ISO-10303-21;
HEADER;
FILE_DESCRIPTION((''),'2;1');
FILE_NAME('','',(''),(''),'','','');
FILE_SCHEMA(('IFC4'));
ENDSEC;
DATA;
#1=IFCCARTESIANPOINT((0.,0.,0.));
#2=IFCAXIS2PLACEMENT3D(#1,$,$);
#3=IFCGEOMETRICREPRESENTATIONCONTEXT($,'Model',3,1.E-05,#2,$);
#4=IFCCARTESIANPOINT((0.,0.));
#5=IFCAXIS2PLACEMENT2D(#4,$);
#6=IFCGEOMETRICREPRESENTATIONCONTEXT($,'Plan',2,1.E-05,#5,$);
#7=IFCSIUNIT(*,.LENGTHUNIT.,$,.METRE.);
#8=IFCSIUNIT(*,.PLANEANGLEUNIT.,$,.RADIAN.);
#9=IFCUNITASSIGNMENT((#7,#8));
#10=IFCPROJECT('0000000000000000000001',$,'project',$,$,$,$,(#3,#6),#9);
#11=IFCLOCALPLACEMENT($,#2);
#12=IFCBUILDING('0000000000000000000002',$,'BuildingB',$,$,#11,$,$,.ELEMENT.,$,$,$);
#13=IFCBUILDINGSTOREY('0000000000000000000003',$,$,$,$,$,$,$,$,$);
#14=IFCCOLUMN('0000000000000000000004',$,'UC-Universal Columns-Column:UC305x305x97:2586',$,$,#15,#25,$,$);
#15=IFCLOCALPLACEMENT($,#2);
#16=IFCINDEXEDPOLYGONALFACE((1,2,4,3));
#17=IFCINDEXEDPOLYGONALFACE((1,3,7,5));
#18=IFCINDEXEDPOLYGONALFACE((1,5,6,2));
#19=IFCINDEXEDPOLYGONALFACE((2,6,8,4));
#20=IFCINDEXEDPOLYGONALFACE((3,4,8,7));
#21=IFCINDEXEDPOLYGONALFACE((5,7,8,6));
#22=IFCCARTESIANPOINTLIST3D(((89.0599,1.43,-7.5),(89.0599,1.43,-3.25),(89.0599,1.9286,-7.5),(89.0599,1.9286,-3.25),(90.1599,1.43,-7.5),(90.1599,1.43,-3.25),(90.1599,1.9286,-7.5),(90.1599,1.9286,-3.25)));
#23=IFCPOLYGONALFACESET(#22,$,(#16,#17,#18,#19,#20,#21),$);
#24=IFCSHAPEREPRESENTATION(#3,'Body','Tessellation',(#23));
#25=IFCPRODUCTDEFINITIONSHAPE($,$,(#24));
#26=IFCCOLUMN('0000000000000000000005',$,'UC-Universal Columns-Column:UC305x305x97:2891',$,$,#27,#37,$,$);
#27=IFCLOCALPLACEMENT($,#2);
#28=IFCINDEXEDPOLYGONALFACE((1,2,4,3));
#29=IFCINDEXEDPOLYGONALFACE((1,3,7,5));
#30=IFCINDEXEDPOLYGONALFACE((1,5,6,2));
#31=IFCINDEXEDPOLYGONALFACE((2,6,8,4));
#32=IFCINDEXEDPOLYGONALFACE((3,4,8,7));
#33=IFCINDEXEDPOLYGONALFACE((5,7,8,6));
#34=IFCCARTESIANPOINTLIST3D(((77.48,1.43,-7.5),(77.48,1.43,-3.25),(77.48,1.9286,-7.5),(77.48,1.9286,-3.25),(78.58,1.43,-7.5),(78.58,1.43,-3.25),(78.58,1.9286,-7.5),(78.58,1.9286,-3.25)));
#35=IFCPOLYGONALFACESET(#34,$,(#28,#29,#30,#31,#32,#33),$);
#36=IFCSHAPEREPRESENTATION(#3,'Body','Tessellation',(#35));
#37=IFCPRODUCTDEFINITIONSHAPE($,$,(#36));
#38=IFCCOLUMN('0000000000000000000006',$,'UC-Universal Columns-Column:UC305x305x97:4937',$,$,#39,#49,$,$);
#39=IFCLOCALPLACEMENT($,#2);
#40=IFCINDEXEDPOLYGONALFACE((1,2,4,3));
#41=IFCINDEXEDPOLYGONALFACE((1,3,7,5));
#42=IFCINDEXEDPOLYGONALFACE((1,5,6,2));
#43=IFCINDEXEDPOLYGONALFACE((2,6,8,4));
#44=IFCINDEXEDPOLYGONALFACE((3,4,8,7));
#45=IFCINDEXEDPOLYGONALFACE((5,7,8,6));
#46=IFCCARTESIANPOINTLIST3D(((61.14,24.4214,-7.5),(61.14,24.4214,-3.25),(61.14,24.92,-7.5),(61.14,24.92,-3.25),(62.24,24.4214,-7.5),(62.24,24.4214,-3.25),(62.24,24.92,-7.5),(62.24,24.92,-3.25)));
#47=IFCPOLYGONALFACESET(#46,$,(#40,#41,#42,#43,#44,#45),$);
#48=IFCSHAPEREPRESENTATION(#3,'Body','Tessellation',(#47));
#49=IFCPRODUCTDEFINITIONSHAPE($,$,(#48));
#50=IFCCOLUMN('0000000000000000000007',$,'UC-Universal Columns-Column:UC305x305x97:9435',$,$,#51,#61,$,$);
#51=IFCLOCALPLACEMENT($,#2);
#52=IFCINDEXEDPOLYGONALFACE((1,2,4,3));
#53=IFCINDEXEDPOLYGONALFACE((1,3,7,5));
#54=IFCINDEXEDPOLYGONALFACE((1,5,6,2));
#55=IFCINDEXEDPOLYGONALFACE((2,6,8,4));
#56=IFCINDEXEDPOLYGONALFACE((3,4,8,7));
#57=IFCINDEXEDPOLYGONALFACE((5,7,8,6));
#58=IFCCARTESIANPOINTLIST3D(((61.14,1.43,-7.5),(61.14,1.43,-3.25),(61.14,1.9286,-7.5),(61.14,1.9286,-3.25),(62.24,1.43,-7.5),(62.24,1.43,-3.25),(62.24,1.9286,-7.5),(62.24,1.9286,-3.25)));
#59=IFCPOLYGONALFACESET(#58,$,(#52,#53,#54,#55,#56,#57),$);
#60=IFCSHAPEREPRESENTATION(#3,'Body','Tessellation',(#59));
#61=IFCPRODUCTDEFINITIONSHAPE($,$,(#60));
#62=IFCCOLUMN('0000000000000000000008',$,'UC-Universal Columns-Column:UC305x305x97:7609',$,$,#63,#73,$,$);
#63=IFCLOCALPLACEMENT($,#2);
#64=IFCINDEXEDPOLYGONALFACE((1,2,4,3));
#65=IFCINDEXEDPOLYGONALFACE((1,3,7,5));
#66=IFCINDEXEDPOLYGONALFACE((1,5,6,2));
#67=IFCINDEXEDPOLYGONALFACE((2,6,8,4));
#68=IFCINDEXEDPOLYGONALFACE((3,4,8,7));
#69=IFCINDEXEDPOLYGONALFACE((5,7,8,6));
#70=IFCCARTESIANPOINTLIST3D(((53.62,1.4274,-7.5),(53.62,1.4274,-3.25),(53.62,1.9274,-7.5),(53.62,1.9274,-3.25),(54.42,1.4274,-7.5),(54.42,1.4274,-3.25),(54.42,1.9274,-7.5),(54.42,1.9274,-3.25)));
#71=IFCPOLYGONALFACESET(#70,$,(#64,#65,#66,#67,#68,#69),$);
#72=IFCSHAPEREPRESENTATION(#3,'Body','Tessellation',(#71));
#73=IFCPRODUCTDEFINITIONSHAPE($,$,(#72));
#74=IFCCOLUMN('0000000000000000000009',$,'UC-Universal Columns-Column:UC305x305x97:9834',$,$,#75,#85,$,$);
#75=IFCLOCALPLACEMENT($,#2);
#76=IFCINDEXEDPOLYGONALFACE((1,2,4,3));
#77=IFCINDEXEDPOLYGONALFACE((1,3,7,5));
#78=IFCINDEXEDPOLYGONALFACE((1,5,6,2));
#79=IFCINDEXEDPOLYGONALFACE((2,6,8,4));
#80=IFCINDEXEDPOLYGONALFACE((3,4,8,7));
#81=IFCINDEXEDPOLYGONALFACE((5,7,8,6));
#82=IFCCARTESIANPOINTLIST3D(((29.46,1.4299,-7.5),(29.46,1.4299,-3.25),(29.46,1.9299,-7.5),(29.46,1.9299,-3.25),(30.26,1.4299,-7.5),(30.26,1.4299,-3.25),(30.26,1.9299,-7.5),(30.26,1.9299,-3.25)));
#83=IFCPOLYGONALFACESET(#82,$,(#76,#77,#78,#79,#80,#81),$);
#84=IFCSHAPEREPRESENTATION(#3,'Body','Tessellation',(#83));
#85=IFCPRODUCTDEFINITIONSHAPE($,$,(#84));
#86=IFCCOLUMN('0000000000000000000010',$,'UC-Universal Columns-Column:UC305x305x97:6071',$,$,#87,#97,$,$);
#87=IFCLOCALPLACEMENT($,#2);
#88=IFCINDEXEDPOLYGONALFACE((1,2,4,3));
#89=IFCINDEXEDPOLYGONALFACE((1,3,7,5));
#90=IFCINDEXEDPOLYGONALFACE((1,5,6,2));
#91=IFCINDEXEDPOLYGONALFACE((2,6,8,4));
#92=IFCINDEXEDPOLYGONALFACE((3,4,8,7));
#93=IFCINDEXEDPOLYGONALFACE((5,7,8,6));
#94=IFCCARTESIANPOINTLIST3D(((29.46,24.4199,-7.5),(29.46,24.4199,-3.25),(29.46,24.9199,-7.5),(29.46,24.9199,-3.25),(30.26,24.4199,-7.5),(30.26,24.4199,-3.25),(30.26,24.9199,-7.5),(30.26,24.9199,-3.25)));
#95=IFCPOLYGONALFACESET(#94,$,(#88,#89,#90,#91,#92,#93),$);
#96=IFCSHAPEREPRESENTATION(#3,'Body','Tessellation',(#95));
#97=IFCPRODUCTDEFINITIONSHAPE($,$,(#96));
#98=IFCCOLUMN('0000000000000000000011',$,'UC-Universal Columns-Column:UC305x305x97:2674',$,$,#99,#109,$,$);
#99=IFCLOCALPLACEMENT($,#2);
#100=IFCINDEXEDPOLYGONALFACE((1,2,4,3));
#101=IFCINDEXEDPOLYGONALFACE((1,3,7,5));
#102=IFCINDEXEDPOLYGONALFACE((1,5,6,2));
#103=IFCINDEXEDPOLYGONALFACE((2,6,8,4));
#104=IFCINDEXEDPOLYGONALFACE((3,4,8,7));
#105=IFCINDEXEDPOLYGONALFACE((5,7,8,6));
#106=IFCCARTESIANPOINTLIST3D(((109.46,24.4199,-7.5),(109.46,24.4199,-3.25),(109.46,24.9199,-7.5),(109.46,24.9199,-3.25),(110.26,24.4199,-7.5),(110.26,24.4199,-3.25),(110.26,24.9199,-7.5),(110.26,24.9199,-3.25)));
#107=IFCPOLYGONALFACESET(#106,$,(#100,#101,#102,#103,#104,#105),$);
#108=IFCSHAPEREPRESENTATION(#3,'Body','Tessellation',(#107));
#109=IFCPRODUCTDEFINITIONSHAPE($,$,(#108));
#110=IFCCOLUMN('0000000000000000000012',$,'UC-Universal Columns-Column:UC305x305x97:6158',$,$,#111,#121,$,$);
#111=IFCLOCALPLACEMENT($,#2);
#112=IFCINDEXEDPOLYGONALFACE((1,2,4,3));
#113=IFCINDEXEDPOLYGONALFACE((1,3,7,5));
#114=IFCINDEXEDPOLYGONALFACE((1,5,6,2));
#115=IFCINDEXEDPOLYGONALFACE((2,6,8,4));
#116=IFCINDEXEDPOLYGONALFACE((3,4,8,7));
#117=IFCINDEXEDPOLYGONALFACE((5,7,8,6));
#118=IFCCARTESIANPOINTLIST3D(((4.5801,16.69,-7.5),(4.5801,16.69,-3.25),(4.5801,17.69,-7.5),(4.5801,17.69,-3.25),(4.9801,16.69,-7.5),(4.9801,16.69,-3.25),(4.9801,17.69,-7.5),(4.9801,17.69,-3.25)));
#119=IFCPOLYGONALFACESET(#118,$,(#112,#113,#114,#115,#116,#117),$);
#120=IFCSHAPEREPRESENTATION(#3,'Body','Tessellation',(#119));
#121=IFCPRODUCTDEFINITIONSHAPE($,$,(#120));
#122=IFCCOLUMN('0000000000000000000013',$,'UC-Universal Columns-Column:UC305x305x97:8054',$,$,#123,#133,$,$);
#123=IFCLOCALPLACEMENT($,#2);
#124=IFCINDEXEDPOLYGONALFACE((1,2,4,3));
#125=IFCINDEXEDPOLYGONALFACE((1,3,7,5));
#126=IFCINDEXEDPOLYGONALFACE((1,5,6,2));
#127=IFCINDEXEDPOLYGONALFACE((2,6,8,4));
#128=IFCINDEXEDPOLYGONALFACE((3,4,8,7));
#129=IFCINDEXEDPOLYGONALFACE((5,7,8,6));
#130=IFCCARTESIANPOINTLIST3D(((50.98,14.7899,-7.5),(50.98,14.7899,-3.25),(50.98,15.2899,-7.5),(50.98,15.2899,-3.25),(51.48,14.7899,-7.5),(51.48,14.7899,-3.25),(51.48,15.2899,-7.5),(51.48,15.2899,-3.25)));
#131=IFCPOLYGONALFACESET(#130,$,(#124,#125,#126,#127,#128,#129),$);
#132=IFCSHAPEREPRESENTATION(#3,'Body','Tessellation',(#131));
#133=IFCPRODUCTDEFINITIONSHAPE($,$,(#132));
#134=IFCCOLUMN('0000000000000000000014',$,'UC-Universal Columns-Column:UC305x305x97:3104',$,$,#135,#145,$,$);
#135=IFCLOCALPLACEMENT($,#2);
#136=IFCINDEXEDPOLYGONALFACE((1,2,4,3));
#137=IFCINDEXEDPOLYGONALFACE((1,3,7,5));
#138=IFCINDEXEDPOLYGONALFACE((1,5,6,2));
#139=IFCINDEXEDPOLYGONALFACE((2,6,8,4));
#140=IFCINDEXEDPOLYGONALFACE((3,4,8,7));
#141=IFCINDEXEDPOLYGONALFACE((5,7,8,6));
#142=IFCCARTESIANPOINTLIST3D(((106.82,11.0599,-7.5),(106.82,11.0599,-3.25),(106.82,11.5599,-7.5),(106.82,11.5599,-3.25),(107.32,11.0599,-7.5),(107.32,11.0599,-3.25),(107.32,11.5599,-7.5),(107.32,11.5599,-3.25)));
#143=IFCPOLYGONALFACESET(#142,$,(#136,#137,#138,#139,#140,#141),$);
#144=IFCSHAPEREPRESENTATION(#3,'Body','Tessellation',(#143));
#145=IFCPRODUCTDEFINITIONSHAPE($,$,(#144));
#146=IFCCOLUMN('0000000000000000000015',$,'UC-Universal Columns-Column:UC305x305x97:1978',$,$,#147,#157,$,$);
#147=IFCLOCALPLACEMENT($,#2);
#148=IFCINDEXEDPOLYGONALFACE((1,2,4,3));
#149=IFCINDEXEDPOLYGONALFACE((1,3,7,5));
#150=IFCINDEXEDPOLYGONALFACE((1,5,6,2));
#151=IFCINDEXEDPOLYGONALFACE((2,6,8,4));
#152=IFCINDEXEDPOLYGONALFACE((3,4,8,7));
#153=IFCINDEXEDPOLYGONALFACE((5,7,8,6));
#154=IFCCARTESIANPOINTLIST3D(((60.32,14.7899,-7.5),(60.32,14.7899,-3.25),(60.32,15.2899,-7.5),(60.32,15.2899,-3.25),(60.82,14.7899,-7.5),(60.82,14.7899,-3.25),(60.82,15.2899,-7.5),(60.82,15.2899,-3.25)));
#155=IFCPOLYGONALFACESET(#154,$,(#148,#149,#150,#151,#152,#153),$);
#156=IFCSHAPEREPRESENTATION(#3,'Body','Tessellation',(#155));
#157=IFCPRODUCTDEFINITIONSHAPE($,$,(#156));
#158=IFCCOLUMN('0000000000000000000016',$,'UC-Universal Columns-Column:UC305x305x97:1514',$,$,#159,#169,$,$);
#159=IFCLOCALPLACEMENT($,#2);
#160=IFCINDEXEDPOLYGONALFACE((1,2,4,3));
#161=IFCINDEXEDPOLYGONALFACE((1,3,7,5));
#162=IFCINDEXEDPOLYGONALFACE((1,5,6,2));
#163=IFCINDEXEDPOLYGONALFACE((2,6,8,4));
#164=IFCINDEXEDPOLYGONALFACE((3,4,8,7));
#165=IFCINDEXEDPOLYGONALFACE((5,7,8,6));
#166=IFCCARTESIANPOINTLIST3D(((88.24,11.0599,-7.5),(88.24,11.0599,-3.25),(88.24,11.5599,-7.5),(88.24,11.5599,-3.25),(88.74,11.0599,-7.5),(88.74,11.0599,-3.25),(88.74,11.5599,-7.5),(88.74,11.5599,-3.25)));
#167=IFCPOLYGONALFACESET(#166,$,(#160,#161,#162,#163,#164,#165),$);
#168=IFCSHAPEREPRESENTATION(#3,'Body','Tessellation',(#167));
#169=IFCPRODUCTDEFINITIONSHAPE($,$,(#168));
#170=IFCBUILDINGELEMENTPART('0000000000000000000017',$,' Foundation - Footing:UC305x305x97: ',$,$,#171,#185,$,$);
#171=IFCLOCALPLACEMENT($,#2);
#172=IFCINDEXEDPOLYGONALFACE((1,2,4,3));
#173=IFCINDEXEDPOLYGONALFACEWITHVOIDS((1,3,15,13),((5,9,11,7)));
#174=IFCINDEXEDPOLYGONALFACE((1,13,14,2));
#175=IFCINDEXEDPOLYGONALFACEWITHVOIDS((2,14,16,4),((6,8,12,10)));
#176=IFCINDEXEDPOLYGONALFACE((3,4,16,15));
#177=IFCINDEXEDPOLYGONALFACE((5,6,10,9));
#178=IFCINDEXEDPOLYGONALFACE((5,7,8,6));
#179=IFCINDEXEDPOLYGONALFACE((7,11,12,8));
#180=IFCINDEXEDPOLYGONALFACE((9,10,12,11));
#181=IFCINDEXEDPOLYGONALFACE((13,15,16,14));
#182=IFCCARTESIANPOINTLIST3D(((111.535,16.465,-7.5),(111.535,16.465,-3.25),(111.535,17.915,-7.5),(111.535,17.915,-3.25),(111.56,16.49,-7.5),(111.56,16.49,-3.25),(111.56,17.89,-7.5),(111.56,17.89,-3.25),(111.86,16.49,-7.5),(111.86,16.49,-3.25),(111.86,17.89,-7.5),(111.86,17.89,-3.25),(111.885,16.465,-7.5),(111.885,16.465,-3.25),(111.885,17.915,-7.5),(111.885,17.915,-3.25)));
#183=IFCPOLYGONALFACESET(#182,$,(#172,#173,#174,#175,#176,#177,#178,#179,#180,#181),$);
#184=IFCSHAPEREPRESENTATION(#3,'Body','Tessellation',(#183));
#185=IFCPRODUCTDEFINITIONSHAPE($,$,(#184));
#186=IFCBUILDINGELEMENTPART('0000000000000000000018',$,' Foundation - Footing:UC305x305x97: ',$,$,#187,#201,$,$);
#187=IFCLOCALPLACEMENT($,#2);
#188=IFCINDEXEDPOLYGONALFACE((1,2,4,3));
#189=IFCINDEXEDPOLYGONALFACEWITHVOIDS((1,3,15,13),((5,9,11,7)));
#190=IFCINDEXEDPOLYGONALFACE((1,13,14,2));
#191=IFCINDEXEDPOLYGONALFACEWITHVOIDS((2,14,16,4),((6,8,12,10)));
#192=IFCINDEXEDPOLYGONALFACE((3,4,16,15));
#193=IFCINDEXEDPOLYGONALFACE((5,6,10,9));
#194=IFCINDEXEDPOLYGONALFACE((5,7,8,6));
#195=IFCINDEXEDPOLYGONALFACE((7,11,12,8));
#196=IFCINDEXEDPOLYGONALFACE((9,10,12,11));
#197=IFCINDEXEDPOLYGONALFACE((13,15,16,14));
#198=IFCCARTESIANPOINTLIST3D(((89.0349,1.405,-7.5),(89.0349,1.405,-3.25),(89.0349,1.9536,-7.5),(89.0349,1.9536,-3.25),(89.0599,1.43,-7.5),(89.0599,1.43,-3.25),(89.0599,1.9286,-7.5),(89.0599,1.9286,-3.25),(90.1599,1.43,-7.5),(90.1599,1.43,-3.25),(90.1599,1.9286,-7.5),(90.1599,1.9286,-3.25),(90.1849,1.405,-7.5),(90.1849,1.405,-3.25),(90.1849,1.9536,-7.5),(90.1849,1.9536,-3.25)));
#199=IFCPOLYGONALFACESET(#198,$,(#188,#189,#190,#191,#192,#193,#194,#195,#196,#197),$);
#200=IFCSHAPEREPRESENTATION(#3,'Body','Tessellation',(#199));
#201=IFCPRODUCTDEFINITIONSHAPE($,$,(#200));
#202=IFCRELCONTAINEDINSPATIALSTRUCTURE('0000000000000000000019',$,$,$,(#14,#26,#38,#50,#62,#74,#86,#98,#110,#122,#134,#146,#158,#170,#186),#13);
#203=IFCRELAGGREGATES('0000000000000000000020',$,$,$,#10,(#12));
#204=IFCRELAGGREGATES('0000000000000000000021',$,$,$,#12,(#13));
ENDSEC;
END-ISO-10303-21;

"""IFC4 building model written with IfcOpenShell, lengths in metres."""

from ifc_helpers import new_model, si_unit, origin, origin_2d, place, context, project, spatial, polyline, outline, extrude, element, save


model = new_model("IFC4")

# Units and contexts
model_context = context("Model", 3, precision=1e-05, world=origin())
plan_context = context("Plan", 2, precision=1e-05, world=origin_2d())
ifc_project = project(units=[si_unit("LENGTHUNIT", "METRE"), si_unit("PLANEANGLEUNIT", "RADIAN")], contexts=[model_context, plan_context])

# Building, storey
building_placement = place(None, origin())
building = spatial("IfcBuilding", under=ifc_project, at=building_placement, Name="BuildingB", CompositionType="ELEMENT")
storey = spatial("IfcBuildingStorey", under=building)

# Columns
element("IfcColumn", 1, inside=storey, Name="UC-Universal Columns-Column:UC305x305x97:2586", context=model_context, shape_type="SweptSolid", body=[
    extrude(outline(polyline([(90.1599, 1.43, -7.5), (89.0599, 1.43, -7.5), (89.0599, 1.9286, -7.5), (90.1599, 1.9286, -7.5), (90.1599, 1.43, -7.5)])), None, (0.0, 0.0, 1.0), 4.25),
])
element("IfcColumn", 2, inside=storey, Name="UC-Universal Columns-Column:UC305x305x97:2891", context=model_context, shape_type="SweptSolid", body=[
    extrude(outline(polyline([(77.48, 1.43, -7.5), (78.58, 1.43, -7.5), (78.58, 1.9286, -7.5), (77.48, 1.9286, -7.5), (77.48, 1.43, -7.5)])), None, (0.0, 0.0, 1.0), 4.25),
])
element("IfcColumn", 3, inside=storey, Name="UC-Universal Columns-Column:UC305x305x97:4937", context=model_context, shape_type="SweptSolid", body=[
    extrude(outline(polyline([(61.14, 24.4214, -7.5), (62.24, 24.4214, -7.5), (62.24, 24.92, -7.5), (61.14, 24.92, -7.5), (61.14, 24.4214, -7.5)])), None, (0.0, 0.0, 1.0), 4.25),
])
element("IfcColumn", 4, inside=storey, Name="UC-Universal Columns-Column:UC305x305x97:9435", context=model_context, shape_type="SweptSolid", body=[
    extrude(outline(polyline([(61.14, 1.43, -7.5), (62.24, 1.43, -7.5), (62.24, 1.9286, -7.5), (61.14, 1.9286, -7.5), (61.14, 1.43, -7.5)])), None, (0.0, 0.0, 1.0), 4.25),
])
element("IfcColumn", 5, inside=storey, Name="UC-Universal Columns-Column:UC305x305x97:7609", context=model_context, shape_type="SweptSolid", body=[
    extrude(outline(polyline([(54.42, 1.4274, -7.5), (53.62, 1.4274, -7.5), (53.62, 1.9274, -7.5), (54.42, 1.9274, -7.5), (54.42, 1.4274, -7.5)])), None, (0.0, 0.0, 1.0), 4.25),
])
element("IfcColumn", 6, inside=storey, Name="UC-Universal Columns-Column:UC305x305x97:9834", context=model_context, shape_type="SweptSolid", body=[
    extrude(outline(polyline([(30.26, 1.4299, -7.5), (29.46, 1.4299, -7.5), (29.46, 1.9299, -7.5), (30.26, 1.9299, -7.5), (30.26, 1.4299, -7.5)])), None, (0.0, 0.0, 1.0), 4.25),
])
element("IfcColumn", 7, inside=storey, Name="UC-Universal Columns-Column:UC305x305x97:6071", context=model_context, shape_type="SweptSolid", body=[
    extrude(outline(polyline([(30.26, 24.4199, -7.5), (29.46, 24.4199, -7.5), (29.46, 24.9199, -7.5), (30.26, 24.9199, -7.5), (30.26, 24.4199, -7.5)])), None, (0.0, 0.0, 1.0), 4.25),
])
element("IfcColumn", 8, inside=storey, Name="UC-Universal Columns-Column:UC305x305x97:2674", context=model_context, shape_type="SweptSolid", body=[
    extrude(outline(polyline([(110.26, 24.4199, -7.5), (109.46, 24.4199, -7.5), (109.46, 24.9199, -7.5), (110.26, 24.9199, -7.5), (110.26, 24.4199, -7.5)])), None, (0.0, 0.0, 1.0), 4.25),
])
element("IfcColumn", 9, inside=storey, Name="UC-Universal Columns-Column:UC305x305x97:6158", context=model_context, shape_type="SweptSolid", body=[
    extrude(outline(polyline([(4.5801, 17.69, -7.5), (4.9801, 17.69, -7.5), (4.9801, 16.69, -7.5), (4.5801, 16.69, -7.5), (4.5801, 17.69, -7.5)])), None, (0.0, 0.0, 1.0), 4.25),
])
element("IfcColumn", 10, inside=storey, Name="UC-Universal Columns-Column:UC305x305x97:8054", context=model_context, shape_type="SweptSolid", body=[
    extrude(outline(polyline([(50.98, 15.2899, -7.5), (51.48, 15.2899, -7.5), (51.48, 14.7899, -7.5), (50.98, 14.7899, -7.5), (50.98, 15.2899, -7.5)])), None, (0.0, 0.0, 1.0), 4.25),
])
element("IfcColumn", 11, inside=storey, Name="UC-Universal Columns-Column:UC305x305x97:3104", context=model_context, shape_type="SweptSolid", body=[
    extrude(outline(polyline([(106.82, 11.0599, -7.5), (107.32, 11.0599, -7.5), (107.32, 11.5599, -7.5), (106.82, 11.5599, -7.5), (106.82, 11.0599, -7.5)])), None, (0.0, 0.0, 1.0), 4.25),
])
element("IfcColumn", 12, inside=storey, Name="UC-Universal Columns-Column:UC305x305x97:1978", context=model_context, shape_type="SweptSolid", body=[
    extrude(outline(polyline([(60.82, 15.2899, -7.5), (60.32, 15.2899, -7.5), (60.32, 14.7899, -7.5), (60.82, 14.7899, -7.5), (60.82, 15.2899, -7.5)])), None, (0.0, 0.0, 1.0), 4.25),
])
element("IfcColumn", 13, inside=storey, Name="UC-Universal Columns-Column:UC305x305x97:1514", context=model_context, shape_type="SweptSolid", body=[
    extrude(outline(polyline([(88.74, 11.0599, -7.5), (88.24, 11.0599, -7.5), (88.24, 11.5599, -7.5), (88.74, 11.5599, -7.5), (88.74, 11.0599, -7.5)])), None, (0.0, 0.0, 1.0), 4.25),
])

# Building element parts, openings
building_element_part_1 = element("IfcBuildingElementPart", 14, inside=storey, Name=" Foundation - Footing:UC305x305x97: ", context=model_context, shape_type="SweptSolid", body=[
    extrude(outline(polyline([(111.885, 17.915, -7.5), (111.535, 17.915, -7.5), (111.535, 16.465, -7.5), (111.885, 16.465, -7.5), (111.885, 17.915, -7.5)])), None, (0.0, 0.0, 1.0), 4.25),
])
element("IfcOpeningElement", 15, inside=storey, cuts=building_element_part_1, context=model_context, shape_type="SweptSolid", body=[
    extrude(outline(polyline([(111.86, 17.89, -7.5), (111.56, 17.89, -7.5), (111.56, 16.49, -7.5), (111.86, 16.49, -7.5), (111.86, 17.89, -7.5)])), None, (0.0, 0.0, 1.0), 4.25),
])
building_element_part_2 = element("IfcBuildingElementPart", 16, inside=storey, Name=" Foundation - Footing:UC305x305x97: ", context=model_context, shape_type="SweptSolid", body=[
    extrude(outline(polyline([(90.1849, 1.405, -7.5), (89.0349, 1.405, -7.5), (89.0349, 1.9536, -7.5), (90.1849, 1.9536, -7.5), (90.1849, 1.405, -7.5)])), None, (0.0, 0.0, 1.0), 4.25),
])
element("IfcOpeningElement", 17, inside=storey, cuts=building_element_part_2, context=model_context, shape_type="SweptSolid", body=[
    extrude(outline(polyline([(90.1599, 1.43, -7.5), (89.0599, 1.43, -7.5), (89.0599, 1.9286, -7.5), (90.1599, 1.9286, -7.5), (90.1599, 1.43, -7.5)])), None, (0.0, 0.0, 1.0), 4.25),
])

save(model, "model.ifc")
